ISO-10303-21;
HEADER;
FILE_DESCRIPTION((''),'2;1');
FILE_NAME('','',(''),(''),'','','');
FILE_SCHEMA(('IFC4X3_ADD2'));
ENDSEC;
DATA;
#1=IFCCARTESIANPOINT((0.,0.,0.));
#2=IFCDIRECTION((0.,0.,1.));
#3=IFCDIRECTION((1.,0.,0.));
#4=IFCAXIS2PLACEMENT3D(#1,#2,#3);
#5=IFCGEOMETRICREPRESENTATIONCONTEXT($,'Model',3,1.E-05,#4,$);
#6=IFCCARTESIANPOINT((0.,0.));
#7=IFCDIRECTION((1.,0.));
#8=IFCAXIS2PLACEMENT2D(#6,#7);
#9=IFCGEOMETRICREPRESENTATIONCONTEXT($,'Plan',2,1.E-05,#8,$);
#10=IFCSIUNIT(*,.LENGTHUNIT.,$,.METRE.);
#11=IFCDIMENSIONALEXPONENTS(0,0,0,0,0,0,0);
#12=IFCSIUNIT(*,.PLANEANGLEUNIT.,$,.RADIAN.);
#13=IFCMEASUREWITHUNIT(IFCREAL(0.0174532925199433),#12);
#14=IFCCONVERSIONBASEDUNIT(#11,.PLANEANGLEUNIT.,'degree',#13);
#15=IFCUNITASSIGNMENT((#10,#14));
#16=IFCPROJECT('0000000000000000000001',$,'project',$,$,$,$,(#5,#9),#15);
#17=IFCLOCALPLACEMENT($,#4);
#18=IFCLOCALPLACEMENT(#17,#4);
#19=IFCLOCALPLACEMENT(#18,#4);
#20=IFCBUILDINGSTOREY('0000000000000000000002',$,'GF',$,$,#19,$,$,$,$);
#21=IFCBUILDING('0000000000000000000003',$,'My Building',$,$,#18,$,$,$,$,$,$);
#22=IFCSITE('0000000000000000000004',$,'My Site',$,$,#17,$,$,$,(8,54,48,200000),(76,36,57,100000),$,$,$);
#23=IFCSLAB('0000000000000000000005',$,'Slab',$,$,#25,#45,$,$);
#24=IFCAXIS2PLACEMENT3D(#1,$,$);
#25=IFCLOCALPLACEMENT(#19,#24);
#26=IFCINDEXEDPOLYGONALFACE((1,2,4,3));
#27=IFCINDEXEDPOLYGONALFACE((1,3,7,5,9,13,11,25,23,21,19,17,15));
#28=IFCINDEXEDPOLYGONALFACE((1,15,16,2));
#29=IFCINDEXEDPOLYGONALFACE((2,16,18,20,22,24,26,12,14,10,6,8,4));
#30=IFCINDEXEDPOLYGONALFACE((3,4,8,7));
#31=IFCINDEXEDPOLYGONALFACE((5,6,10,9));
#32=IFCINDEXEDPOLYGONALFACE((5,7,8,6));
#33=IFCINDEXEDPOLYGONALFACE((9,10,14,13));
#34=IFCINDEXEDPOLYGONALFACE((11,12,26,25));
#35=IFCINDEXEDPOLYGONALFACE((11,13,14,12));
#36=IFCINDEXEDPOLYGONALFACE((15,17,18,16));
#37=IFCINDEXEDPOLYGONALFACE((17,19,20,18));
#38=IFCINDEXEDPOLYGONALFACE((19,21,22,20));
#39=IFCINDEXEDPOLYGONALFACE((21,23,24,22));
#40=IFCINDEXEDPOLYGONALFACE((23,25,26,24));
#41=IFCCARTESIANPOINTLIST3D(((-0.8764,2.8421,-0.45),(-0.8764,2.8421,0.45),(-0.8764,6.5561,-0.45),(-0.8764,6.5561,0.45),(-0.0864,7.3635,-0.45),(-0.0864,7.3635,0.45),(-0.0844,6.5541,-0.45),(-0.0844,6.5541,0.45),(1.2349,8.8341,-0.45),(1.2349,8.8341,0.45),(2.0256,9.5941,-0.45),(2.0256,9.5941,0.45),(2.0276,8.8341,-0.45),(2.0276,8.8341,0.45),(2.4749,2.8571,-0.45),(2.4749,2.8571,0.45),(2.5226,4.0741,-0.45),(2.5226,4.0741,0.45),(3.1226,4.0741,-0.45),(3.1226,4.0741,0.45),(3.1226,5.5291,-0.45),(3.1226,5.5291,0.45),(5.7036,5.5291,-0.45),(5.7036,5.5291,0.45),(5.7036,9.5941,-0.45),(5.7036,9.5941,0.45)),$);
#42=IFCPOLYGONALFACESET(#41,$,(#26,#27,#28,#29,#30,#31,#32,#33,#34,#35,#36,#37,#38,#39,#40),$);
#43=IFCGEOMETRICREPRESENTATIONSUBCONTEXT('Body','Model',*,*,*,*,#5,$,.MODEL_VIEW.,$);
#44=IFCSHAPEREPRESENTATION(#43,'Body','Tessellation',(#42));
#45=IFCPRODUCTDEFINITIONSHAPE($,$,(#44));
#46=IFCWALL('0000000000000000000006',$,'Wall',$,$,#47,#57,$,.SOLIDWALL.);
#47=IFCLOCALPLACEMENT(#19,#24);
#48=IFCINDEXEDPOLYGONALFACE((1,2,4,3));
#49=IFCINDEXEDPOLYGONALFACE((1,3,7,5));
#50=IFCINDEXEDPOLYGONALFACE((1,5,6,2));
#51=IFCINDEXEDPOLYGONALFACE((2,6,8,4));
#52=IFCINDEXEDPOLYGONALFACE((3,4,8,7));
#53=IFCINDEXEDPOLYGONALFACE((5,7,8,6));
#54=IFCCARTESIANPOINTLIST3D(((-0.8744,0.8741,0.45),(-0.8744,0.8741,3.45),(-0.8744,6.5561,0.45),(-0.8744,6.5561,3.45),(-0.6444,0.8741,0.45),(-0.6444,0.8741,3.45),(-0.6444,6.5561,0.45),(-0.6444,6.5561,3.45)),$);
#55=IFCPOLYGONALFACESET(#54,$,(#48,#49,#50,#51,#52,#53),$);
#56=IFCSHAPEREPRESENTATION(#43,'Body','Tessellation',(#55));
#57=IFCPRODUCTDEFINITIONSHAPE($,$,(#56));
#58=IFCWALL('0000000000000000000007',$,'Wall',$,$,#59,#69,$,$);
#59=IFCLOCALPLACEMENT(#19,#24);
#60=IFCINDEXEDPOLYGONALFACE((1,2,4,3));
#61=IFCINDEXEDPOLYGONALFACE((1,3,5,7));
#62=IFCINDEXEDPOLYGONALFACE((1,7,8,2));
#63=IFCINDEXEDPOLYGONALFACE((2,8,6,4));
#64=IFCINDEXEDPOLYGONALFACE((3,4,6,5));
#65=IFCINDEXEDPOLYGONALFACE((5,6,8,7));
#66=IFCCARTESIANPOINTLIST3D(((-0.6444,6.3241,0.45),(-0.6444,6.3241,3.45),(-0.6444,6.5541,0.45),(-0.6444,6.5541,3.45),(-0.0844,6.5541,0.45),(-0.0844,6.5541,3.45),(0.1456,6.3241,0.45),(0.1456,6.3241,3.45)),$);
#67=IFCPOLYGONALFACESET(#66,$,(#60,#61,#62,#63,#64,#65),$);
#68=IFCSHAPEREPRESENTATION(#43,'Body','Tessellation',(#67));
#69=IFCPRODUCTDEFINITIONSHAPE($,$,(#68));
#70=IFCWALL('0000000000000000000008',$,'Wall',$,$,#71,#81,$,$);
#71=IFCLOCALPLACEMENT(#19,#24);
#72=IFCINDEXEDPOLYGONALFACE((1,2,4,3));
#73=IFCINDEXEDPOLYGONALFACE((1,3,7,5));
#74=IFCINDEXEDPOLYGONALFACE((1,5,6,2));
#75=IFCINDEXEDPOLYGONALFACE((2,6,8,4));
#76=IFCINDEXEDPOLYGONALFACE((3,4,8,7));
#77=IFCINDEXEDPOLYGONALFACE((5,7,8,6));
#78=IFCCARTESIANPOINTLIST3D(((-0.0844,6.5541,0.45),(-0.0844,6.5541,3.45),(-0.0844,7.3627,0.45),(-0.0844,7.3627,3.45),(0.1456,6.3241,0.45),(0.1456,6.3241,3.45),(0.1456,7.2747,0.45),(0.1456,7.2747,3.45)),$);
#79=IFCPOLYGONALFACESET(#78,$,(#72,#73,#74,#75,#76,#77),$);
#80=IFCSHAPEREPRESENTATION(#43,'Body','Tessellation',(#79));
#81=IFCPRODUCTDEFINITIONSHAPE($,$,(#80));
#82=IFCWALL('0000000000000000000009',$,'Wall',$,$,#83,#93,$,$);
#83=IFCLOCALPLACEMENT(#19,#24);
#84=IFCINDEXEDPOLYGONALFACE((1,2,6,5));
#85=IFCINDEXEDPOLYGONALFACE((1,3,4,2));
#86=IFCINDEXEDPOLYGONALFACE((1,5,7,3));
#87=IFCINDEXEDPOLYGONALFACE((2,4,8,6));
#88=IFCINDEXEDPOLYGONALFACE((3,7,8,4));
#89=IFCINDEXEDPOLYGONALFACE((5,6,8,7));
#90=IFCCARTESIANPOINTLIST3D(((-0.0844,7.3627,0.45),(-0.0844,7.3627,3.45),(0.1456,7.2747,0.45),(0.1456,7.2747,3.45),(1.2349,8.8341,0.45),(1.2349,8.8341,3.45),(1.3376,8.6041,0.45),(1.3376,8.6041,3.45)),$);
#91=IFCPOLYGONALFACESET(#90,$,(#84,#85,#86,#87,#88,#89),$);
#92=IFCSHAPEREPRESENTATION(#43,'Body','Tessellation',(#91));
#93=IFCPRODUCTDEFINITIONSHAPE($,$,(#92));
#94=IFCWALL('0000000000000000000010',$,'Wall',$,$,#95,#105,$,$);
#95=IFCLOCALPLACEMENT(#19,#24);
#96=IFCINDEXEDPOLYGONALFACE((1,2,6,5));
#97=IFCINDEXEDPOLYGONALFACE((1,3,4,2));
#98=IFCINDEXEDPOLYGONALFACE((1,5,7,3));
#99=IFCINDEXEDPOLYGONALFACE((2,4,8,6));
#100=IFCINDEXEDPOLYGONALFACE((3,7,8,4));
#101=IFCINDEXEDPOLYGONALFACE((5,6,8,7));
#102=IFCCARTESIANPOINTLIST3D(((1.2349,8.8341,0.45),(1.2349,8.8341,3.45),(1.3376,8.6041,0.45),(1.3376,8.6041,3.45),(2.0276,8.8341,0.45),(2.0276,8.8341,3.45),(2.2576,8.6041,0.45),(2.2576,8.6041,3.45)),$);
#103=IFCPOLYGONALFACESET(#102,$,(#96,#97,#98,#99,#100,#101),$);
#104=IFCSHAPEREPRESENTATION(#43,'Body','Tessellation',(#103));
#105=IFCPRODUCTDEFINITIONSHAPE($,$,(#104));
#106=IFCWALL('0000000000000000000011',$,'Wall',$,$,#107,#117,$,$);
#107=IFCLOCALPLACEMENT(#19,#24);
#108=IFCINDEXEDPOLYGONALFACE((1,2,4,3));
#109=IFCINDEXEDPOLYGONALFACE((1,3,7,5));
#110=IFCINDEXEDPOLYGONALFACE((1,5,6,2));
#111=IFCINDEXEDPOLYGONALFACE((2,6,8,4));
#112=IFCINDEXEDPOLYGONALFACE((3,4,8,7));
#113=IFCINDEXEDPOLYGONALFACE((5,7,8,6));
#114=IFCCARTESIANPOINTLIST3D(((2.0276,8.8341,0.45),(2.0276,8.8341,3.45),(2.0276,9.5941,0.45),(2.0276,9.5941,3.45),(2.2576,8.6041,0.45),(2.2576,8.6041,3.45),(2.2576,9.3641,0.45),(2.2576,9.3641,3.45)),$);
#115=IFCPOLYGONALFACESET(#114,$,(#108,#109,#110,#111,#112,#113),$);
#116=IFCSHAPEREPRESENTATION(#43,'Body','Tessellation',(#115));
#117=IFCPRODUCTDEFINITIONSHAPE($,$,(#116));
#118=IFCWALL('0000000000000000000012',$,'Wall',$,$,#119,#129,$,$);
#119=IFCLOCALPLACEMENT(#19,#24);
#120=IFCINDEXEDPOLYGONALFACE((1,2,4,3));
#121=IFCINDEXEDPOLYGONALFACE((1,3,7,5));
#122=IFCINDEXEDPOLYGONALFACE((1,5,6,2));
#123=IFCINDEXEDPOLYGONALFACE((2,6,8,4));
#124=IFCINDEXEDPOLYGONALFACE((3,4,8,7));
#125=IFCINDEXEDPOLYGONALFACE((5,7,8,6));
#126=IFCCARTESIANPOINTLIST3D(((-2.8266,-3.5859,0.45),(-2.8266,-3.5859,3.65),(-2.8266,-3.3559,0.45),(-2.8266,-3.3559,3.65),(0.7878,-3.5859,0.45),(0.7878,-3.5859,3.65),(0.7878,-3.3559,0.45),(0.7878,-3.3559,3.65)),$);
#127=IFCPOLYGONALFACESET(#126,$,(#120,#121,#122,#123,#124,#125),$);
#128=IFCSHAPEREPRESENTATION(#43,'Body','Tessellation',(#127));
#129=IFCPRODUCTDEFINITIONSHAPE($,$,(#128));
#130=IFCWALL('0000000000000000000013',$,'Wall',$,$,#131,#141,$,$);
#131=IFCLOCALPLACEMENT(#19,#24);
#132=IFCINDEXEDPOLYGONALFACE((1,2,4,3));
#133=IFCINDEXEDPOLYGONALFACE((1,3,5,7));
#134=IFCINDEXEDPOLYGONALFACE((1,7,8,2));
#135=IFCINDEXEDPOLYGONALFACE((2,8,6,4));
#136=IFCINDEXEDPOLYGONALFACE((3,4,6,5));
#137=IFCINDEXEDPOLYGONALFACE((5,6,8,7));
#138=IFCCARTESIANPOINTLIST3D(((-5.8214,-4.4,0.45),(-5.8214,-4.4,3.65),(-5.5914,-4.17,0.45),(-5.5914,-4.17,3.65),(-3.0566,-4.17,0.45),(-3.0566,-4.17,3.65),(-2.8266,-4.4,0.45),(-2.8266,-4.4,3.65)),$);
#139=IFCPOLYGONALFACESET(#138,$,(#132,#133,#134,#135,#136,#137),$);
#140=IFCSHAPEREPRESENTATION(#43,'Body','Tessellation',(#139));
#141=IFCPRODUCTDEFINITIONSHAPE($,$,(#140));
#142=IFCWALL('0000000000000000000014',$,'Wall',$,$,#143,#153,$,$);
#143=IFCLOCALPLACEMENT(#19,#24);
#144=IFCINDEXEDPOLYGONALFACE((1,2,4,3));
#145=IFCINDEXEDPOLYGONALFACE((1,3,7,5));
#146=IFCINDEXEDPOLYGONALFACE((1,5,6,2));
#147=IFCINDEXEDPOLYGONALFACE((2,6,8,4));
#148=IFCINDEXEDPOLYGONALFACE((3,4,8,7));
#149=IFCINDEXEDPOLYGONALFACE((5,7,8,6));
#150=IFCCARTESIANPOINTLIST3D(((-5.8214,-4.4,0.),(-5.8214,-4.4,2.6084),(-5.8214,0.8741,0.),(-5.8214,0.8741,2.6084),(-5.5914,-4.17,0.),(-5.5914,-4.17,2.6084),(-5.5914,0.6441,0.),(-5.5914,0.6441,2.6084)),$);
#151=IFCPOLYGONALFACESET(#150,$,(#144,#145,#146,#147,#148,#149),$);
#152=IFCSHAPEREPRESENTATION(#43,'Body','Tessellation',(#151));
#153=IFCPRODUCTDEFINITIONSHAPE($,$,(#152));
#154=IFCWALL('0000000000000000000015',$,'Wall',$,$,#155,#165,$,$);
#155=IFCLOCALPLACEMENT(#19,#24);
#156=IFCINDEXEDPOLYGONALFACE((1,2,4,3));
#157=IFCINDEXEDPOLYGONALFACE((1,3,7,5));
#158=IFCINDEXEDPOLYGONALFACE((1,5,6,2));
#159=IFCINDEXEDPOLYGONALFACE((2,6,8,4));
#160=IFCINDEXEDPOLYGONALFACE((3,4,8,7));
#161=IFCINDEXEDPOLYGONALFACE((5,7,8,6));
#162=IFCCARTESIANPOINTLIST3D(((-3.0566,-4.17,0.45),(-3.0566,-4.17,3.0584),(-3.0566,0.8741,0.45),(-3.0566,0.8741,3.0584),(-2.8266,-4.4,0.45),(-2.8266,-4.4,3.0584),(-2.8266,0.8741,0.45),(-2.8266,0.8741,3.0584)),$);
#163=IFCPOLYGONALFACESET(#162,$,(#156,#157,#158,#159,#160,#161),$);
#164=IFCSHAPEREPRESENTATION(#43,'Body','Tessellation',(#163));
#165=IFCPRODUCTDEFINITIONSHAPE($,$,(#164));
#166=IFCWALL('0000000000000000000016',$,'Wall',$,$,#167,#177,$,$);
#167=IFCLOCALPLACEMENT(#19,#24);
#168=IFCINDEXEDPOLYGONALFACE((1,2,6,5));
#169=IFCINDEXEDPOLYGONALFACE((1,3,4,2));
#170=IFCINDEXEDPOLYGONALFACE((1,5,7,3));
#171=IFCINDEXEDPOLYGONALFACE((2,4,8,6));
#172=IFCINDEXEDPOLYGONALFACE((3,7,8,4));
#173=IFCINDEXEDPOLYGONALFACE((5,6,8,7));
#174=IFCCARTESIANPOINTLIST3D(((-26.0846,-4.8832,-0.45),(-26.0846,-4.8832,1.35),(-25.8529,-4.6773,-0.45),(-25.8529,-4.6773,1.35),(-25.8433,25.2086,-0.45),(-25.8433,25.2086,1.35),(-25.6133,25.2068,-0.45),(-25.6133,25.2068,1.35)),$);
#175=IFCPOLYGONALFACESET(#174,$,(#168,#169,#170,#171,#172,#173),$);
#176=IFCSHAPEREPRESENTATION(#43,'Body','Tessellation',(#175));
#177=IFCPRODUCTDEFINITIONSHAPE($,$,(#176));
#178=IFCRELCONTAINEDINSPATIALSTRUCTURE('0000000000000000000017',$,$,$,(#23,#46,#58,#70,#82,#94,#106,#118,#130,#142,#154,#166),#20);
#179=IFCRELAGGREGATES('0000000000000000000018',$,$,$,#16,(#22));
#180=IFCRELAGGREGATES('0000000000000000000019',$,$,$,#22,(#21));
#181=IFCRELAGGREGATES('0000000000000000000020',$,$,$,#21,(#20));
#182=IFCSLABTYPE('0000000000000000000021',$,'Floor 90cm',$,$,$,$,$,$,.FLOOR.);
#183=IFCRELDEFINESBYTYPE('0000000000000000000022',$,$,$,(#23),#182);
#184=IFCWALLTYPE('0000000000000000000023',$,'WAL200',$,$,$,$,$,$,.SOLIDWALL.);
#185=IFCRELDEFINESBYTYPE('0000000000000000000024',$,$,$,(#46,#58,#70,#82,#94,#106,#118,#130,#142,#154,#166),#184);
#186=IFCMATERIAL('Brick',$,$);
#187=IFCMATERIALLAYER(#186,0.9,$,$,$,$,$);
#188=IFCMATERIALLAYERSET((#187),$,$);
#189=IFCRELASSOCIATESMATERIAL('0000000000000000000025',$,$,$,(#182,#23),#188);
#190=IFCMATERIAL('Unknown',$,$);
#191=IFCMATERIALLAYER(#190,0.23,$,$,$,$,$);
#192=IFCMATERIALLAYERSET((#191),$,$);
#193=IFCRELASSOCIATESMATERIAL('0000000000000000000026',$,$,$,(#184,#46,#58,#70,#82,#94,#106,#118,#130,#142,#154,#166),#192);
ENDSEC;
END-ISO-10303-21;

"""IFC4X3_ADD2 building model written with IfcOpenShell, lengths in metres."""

from ifc_helpers import new_model, entity, si_unit, converted_unit, frame, origin_with_axes, origin_2d_with_axis, place, context, subcontext, project, spatial, line, indexed_curve, outline, extrude, material, layer, layer_set, layer_usage, type_object, element, save


model = new_model("IFC4X3_ADD2")

# Units and contexts
model_context = context("Model", 3, precision=1e-05, world=origin_with_axes())
plan_context = context("Plan", 2, precision=1e-05, world=origin_2d_with_axis())
body_context = subcontext(model_context, "Body", "Model", "MODEL_VIEW")
ifc_project = project(units=[si_unit("LENGTHUNIT", "METRE"), converted_unit("PLANEANGLEUNIT", "degree", entity("IfcReal", 0.0174532925199433), si_unit("PLANEANGLEUNIT", "RADIAN"), dimensions=[0, 0, 0, 0, 0, 0, 0])], contexts=[model_context, plan_context])

# Site, building, storey
site_placement = place(None, origin_with_axes())
site = spatial("IfcSite", under=ifc_project, at=site_placement, Name="My Site", RefLatitude=(8, 54, 48, 200000), RefLongitude=(76, 36, 57, 100000))
building_placement = place(site_placement, origin_with_axes())
building = spatial("IfcBuilding", under=site, at=building_placement, Name="My Building")
storey_placement = place(building_placement, origin_with_axes())
storey = spatial("IfcBuildingStorey", under=building, at=storey_placement, Name="GF")

# Slab
ifc_material_1 = material(Name="Brick")
ifc_layer_1 = layer(ifc_material_1, 0.9)
ifc_layer_set_1 = layer_set([ifc_layer_1])
ifc_layer_usage_1 = layer_usage(ifc_layer_set_1, "AXIS3", "POSITIVE", -0.45)
slab_type_1 = type_object("IfcSlabType", Name="Floor 90cm", PredefinedType="FLOOR", material=ifc_layer_set_1)
slab_1_placement = place(storey_placement, frame((-0.8764, 2.8421, 0.0), z_axis=(0.0, 0.0, 1.0), x_axis=(1.0, 0.0, 0.0)))
element("IfcSlab", 1, at=slab_1_placement, inside=storey, type_object=slab_type_1, material=ifc_layer_usage_1, Name="Slab", context=body_context, shape_type="SweptSolid", body=[
    extrude(outline(indexed_curve([(3.3513, 0.0151), (3.399, 1.232), (3.999, 1.232), (3.999, 2.687), (6.58, 2.687), (6.58, 6.752), (2.902, 6.752), (2.904, 5.992), (2.1113, 5.992), (0.79, 4.5214), (0.792, 3.712), (0.0, 3.714), (0.0, 0.0), (3.3513, 0.0151)])), frame((0.0, 0.0, -0.45), z_axis=(0.0, 0.0, 1.0), x_axis=(1.0, 0.0, 0.0)), (0.0, 0.0, 1.0), 0.9),
])

# Walls
ifc_material_2 = material(Name="Unknown")
ifc_layer_2 = layer(ifc_material_2, 0.23)
ifc_layer_set_2 = layer_set([ifc_layer_2])
ifc_layer_usage_2 = layer_usage(ifc_layer_set_2, "AXIS2", "POSITIVE", 0.0)
wall_type = type_object("IfcWallType", Name="WAL200", PredefinedType="SOLIDWALL", material=ifc_layer_set_2)
wall_1_placement = place(storey_placement, frame((-0.6444, 0.8741, 0.45), z_axis=(0.0, 0.0, 1.0), x_axis=(0.0, 1.0, 0.0)))
element("IfcWall", 2, at=wall_1_placement, inside=storey, type_object=wall_type, material=ifc_layer_usage_2, Name="Wall", PredefinedType="SOLIDWALL", context=body_context, shape_type="SweptSolid", body=[
    extrude(outline(indexed_curve([(0.0, 0.0), (0.0, 0.23), (5.682, 0.23), (5.682, 0.0)], segments=[line(1, 2, 3, 4, 1)])), origin_with_axes(), (0.0, 0.0, 1.0), 3.0),
])
ifc_layer_usage_3 = layer_usage(ifc_layer_set_2, "AXIS2", "POSITIVE", 0.0)
wall_2_placement = place(storey_placement, frame((-0.6444, 6.3241, 0.45), z_axis=(0.0, 0.0, 1.0), x_axis=(1.0, 0.0, 0.0)))
element("IfcWall", 3, at=wall_2_placement, inside=storey, type_object=wall_type, material=ifc_layer_usage_3, Name="Wall", context=body_context, shape_type="SweptSolid", body=[
    extrude(outline(indexed_curve([(0.0, 0.0), (0.0, 0.23), (0.56, 0.23), (0.79, 0.0)], segments=[line(1, 2, 3, 4, 1)])), origin_with_axes(), (0.0, 0.0, 1.0), 3.0),
])
ifc_layer_usage_4 = layer_usage(ifc_layer_set_2, "AXIS2", "POSITIVE", 0.0)
wall_3_placement = place(storey_placement, frame((0.1456, 6.3241, 0.45), z_axis=(0.0, 0.0, 1.0), x_axis=(0.0, 1.0, 0.0)))
element("IfcWall", 4, at=wall_3_placement, inside=storey, type_object=wall_type, material=ifc_layer_usage_4, Name="Wall", context=body_context, shape_type="SweptSolid", body=[
    extrude(outline(indexed_curve([(0.0, 0.0), (0.23, 0.23), (1.0387, 0.23), (0.9507, 0.0)], segments=[line(1, 2, 3, 4, 1)])), origin_with_axes(), (0.0, 0.0, 1.0), 3.0),
])
ifc_layer_usage_5 = layer_usage(ifc_layer_set_2, "AXIS2", "POSITIVE", 0.0)
wall_4_placement = place(storey_placement, frame((0.1456, 7.2747, 0.45), z_axis=(0.0, 0.0, 1.0), x_axis=(0.6676, 0.74452, 0.0)))
element("IfcWall", 5, at=wall_4_placement, inside=storey, type_object=wall_type, material=ifc_layer_usage_5, Name="Wall", context=body_context, shape_type="SweptSolid", body=[
    extrude(outline(indexed_curve([(0.0, 0.0), (-0.088, 0.23), (1.8882, 0.23), (1.7855, 0.0)], segments=[line(1, 2, 3, 4, 1)])), origin_with_axes(), (0.0, 0.0, 1.0), 3.0),
])
ifc_layer_usage_6 = layer_usage(ifc_layer_set_2, "AXIS2", "POSITIVE", 0.0)
wall_5_placement = place(storey_placement, frame((1.3376, 8.6041, 0.45), z_axis=(0.0, 0.0, 1.0), x_axis=(1.0, 0.0, 0.0)))
element("IfcWall", 6, at=wall_5_placement, inside=storey, type_object=wall_type, material=ifc_layer_usage_6, Name="Wall", context=body_context, shape_type="SweptSolid", body=[
    extrude(outline(indexed_curve([(0.0, 0.0), (-0.1027, 0.23), (0.69, 0.23), (0.92, 0.0)], segments=[line(1, 2, 3, 4, 1)])), origin_with_axes(), (0.0, 0.0, 1.0), 3.0),
])
ifc_layer_usage_7 = layer_usage(ifc_layer_set_2, "AXIS2", "POSITIVE", 0.0)
wall_6_placement = place(storey_placement, frame((2.2576, 8.6041, 0.45), z_axis=(0.0, 0.0, 1.0), x_axis=(0.0, 1.0, 0.0)))
element("IfcWall", 7, at=wall_6_placement, inside=storey, type_object=wall_type, material=ifc_layer_usage_7, Name="Wall", context=body_context, shape_type="SweptSolid", body=[
    extrude(outline(indexed_curve([(0.0, 0.0), (0.23, 0.23), (0.99, 0.23), (0.76, 0.0)], segments=[line(1, 2, 3, 4, 1)])), origin_with_axes(), (0.0, 0.0, 1.0), 3.0),
])
ifc_layer_usage_8 = layer_usage(ifc_layer_set_2, "AXIS2", "POSITIVE", 0.0)
wall_7_placement = place(storey_placement, frame((0.7878, -3.3559, 0.45), z_axis=(0.0, 0.0, 1.0), x_axis=(-1.0, 0.0, 0.0)))
element("IfcWall", 8, at=wall_7_placement, inside=storey, type_object=wall_type, material=ifc_layer_usage_8, Name="Wall", context=body_context, shape_type="SweptSolid", body=[
    extrude(outline(indexed_curve([(0.0, 0.0), (0.0, 0.23), (3.6144, 0.23), (3.6144, 0.0)], segments=[line(1, 2, 3, 4, 1)])), origin_with_axes(), (0.0, 0.0, 1.0), 3.2),
])
ifc_layer_usage_9 = layer_usage(ifc_layer_set_2, "AXIS2", "POSITIVE", 0.0)
wall_8_placement = place(storey_placement, frame((-2.8266, -4.17, 0.45), z_axis=(0.0, 0.0, 1.0), x_axis=(-1.0, 0.0, 0.0)))
element("IfcWall", 9, at=wall_8_placement, inside=storey, type_object=wall_type, material=ifc_layer_usage_9, Name="Wall", context=body_context, shape_type="SweptSolid", body=[
    extrude(outline(indexed_curve([(0.23, 0.0), (0.0, 0.23), (2.9948, 0.23), (2.7648, 0.0)], segments=[line(1, 2, 3, 4, 1)])), origin_with_axes(), (0.0, 0.0, 1.0), 3.2),
])
ifc_layer_usage_10 = layer_usage(ifc_layer_set_2, "AXIS2", "POSITIVE", 0.0)
wall_9_placement = place(storey_placement, frame((-5.5914, -4.17, 0.0), z_axis=(0.0, 0.0, 1.0), x_axis=(0.000001, 1.0, 0.0)))
element("IfcWall", 10, at=wall_9_placement, inside=storey, type_object=wall_type, material=ifc_layer_usage_10, Name="Wall", context=body_context, shape_type="SweptSolid", body=[
    extrude(outline(indexed_curve([(0.0, 0.0), (-0.23, 0.23), (5.0441, 0.23), (4.8141, 0.0)], segments=[line(1, 2, 3, 4, 1)])), origin_with_axes(), (0.0, 0.0, 1.0), 2.6084),
])
ifc_layer_usage_11 = layer_usage(ifc_layer_set_2, "AXIS2", "POSITIVE", 0.0)
wall_10_placement = place(storey_placement, frame((-2.8266, -4.17, 0.45), z_axis=(0.0, 0.0, 1.0), x_axis=(0.000001, 1.0, 0.0)))
element("IfcWall", 11, at=wall_10_placement, inside=storey, type_object=wall_type, material=ifc_layer_usage_11, Name="Wall", context=body_context, shape_type="SweptSolid", body=[
    extrude(outline(indexed_curve([(-0.23, 0.0), (0.0, 0.23), (5.0441, 0.23), (5.0441, 0.0)], segments=[line(1, 2, 3, 4, 1)])), origin_with_axes(), (0.0, 0.0, 1.0), 2.6084),
])
ifc_layer_usage_12 = layer_usage(ifc_layer_set_2, "AXIS2", "NEGATIVE", 0.0)
wall_11_placement = place(storey_placement, frame((-26.0846, -4.8832, -0.45), z_axis=(0.0, 0.0, 1.0), x_axis=(0.008019, 0.999968, 0.0)))
element("IfcWall", 12, at=wall_11_placement, inside=storey, type_object=wall_type, material=ifc_layer_usage_12, Name="Wall", context=body_context, shape_type="SweptSolid", body=[
    extrude(outline(indexed_curve([(0.2077, -0.23), (0.0, 0.0), (30.0927, 0.0), (30.0927, -0.23)], segments=[line(1, 2, 3, 4, 1)])), origin_with_axes(), (0.0, 0.0, 1.0), 1.8),
])

save(model, "model.ifc")
